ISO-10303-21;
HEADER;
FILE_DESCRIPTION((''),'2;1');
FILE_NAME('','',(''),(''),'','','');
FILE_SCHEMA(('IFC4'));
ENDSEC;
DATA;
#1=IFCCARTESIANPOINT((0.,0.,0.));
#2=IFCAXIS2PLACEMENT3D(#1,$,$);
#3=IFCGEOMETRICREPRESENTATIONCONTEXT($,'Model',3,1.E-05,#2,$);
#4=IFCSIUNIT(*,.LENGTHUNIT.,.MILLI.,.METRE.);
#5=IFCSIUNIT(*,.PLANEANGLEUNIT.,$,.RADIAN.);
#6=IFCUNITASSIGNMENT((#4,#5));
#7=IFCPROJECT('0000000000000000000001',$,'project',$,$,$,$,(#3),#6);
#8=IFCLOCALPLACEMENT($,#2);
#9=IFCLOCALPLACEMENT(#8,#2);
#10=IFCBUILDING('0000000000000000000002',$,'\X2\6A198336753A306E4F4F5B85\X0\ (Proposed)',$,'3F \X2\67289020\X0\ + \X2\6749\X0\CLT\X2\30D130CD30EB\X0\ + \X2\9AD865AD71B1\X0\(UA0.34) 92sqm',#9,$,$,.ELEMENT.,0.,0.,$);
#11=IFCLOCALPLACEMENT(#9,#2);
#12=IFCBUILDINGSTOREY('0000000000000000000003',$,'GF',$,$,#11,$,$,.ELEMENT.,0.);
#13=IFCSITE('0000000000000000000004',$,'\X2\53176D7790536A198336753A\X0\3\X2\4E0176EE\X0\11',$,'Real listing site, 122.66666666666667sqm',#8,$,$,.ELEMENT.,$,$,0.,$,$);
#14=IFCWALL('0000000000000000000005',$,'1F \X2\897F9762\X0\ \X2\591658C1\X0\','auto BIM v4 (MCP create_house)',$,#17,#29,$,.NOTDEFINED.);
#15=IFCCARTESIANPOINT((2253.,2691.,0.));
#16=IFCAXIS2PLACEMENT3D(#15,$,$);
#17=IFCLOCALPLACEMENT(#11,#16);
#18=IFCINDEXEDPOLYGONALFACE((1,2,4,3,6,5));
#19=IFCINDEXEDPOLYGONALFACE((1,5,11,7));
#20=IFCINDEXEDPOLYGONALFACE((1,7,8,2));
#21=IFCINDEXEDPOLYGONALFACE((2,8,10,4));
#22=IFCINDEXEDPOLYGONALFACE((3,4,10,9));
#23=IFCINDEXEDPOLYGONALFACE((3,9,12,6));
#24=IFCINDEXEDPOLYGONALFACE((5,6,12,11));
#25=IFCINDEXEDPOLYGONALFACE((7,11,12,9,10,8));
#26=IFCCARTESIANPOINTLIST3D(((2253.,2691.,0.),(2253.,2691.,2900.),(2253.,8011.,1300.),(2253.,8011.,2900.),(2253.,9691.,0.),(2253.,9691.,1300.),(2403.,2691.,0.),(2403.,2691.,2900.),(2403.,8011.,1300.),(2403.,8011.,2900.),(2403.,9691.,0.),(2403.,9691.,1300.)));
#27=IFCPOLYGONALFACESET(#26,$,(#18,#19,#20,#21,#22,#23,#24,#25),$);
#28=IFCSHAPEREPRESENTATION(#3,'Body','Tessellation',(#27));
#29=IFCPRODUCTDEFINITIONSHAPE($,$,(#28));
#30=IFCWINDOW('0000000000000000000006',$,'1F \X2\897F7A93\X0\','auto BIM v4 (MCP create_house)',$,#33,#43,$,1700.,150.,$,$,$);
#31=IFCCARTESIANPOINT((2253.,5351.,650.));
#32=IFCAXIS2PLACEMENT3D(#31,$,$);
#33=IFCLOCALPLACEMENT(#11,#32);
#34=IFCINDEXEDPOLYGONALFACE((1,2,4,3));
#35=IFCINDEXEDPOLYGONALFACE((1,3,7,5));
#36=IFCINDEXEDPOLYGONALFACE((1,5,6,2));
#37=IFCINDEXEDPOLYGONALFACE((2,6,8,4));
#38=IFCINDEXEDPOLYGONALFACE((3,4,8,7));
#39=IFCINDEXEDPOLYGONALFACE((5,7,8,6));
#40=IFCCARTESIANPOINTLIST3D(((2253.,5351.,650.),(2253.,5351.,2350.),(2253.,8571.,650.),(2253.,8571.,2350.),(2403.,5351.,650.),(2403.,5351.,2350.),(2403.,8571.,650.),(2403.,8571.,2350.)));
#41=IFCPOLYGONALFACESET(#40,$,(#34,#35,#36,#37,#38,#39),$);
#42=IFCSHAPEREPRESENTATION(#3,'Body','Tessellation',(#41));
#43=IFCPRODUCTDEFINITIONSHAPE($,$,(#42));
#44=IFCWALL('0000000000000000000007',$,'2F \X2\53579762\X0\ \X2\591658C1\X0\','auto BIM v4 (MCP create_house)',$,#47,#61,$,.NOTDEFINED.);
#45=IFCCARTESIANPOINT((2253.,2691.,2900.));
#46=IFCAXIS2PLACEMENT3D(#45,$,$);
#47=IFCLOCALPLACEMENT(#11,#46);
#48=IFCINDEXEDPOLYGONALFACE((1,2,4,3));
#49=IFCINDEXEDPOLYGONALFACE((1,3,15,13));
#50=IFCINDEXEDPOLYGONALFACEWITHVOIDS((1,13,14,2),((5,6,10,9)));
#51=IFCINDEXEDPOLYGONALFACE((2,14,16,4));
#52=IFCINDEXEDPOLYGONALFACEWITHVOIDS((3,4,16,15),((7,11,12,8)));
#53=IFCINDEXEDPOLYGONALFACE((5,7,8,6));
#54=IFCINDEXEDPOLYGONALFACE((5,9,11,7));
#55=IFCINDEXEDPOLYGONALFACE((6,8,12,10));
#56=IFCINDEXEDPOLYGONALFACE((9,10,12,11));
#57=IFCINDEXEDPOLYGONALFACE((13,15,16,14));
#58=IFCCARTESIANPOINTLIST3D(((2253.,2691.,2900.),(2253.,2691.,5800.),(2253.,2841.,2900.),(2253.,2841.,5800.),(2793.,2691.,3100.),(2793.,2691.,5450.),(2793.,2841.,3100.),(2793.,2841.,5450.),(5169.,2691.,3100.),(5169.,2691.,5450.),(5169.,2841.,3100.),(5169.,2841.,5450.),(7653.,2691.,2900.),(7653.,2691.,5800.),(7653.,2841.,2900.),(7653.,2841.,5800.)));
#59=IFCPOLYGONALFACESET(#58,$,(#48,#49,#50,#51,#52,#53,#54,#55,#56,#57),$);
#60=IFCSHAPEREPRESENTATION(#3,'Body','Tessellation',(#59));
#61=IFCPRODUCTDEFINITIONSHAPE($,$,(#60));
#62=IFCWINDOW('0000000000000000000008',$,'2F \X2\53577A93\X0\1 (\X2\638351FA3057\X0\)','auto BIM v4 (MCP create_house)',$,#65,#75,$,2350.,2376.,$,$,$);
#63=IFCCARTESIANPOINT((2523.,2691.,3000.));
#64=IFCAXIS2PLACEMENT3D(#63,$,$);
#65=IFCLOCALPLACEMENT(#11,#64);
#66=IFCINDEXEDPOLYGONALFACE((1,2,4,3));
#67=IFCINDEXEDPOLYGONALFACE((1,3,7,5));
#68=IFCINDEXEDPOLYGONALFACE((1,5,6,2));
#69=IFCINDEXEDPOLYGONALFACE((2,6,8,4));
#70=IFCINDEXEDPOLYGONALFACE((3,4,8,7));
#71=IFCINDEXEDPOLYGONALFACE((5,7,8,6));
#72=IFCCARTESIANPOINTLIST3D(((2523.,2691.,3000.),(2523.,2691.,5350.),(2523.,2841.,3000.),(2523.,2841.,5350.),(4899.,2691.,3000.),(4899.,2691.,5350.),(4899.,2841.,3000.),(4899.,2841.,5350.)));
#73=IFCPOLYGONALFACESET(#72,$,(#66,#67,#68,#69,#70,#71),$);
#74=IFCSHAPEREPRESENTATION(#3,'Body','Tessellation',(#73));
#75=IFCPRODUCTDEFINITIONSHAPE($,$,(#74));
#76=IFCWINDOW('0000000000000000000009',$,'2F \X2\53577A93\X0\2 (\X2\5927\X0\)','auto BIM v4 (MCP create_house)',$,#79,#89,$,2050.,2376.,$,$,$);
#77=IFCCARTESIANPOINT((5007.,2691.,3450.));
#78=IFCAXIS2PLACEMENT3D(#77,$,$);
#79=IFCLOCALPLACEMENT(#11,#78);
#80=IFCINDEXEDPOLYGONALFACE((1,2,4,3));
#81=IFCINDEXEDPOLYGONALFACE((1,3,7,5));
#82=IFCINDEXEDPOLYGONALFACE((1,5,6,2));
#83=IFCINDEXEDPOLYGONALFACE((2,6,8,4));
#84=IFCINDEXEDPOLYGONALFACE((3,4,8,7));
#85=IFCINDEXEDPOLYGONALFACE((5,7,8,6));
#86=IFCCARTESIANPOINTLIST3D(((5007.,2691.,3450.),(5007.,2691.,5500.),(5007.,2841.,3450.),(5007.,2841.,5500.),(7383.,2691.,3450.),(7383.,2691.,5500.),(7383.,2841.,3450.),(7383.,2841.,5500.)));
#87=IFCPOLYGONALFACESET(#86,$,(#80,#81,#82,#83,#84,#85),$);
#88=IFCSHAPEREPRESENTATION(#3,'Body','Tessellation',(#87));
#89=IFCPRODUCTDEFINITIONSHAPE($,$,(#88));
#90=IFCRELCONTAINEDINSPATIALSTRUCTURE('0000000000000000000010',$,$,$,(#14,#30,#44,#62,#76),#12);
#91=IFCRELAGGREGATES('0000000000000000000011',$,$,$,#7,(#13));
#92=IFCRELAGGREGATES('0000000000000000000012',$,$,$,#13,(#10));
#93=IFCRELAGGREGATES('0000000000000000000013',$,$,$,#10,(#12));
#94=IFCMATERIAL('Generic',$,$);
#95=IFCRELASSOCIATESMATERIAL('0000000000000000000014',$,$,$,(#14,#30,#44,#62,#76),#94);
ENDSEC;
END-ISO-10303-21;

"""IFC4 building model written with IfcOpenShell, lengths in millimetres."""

from ifc_helpers import new_model, si_unit, frame, frame_2d, origin, place, context, project, spatial, rectangle, extrude, material, element, fill, save


model = new_model("IFC4")

# Units and contexts
model_context = context("Model", 3, precision=1e-05, world=origin())
ifc_project = project(units=[si_unit("LENGTHUNIT", "METRE", prefix="MILLI"), si_unit("PLANEANGLEUNIT", "RADIAN")], contexts=[model_context])

# Site, building, storey
site_placement = place(None, origin())
site = spatial("IfcSite", under=ifc_project, at=site_placement, Name="北海道標茶町3丁目11", ObjectType="Real listing site, 122.66666666666667sqm", CompositionType="ELEMENT", RefElevation=0.0)
building_placement = place(site_placement, origin())
building = spatial("IfcBuilding", under=site, at=building_placement, Name="標茶町の住宅 (Proposed)", ObjectType="3F 木造 + 杉CLTパネル + 高断熱(UA0.34) 92sqm", CompositionType="ELEMENT", ElevationOfRefHeight=0.0, ElevationOfTerrain=0.0)
storey_placement = place(building_placement, origin())
storey = spatial("IfcBuildingStorey", under=building, at=storey_placement, Name="GF", CompositionType="ELEMENT", Elevation=0.0)

# Shared definitions
ifc_material = material(Name="Generic")

# Wall, opening, window
wall_1_placement = place(storey_placement, frame((2253.0, 2691.0, 0.0)))
wall_1 = element("IfcWall", 1, at=wall_1_placement, inside=storey, material=ifc_material, Name="1F 西面 外壁", Description="auto BIM v4 (MCP create_house)", PredefinedType="NOTDEFINED", context=model_context, shape_type="SweptSolid", body=[
    extrude(rectangle(XDim=150.0, YDim=7000.0, at=frame_2d((75.0, 3500.0))), frame((2253.0, 2691.0, 0.0)), (0.0, 0.0, 1.0), 2900.0),
])
opening_1_placement = place(storey_placement, frame((2253.0, 5351.0, 650.0)))
opening_1 = element("IfcOpeningElement", 2, at=opening_1_placement, cuts=wall_1, PredefinedType="NOTDEFINED", context=model_context, shape_type="SweptSolid", body=[
    extrude(rectangle(XDim=150.0, YDim=3220.0, at=frame_2d((75.0, 1610.0))), frame((2253.0, 5351.0, 650.0)), (0.0, 0.0, 1.0), 1700.0),
])
window_1_placement = place(storey_placement, frame((2253.0, 5351.0, 650.0)))
window_1 = element("IfcWindow", 3, at=window_1_placement, inside=storey, material=ifc_material, Name="1F 西窓", Description="auto BIM v4 (MCP create_house)", OverallHeight=1700.0, OverallWidth=150.0, context=model_context, shape_type="SweptSolid", body=[
    extrude(rectangle(XDim=150.0, YDim=3220.0, at=frame_2d((75.0, 1610.0))), frame((2253.0, 5351.0, 650.0)), (0.0, 0.0, 1.0), 1700.0),
])
fill(opening_1, window_1)

# Wall, openings, windows
wall_2_placement = place(storey_placement, frame((2253.0, 2691.0, 2900.0)))
wall_2 = element("IfcWall", 4, at=wall_2_placement, inside=storey, material=ifc_material, Name="2F 南面 外壁", Description="auto BIM v4 (MCP create_house)", PredefinedType="NOTDEFINED", context=model_context, shape_type="SweptSolid", body=[
    extrude(rectangle(XDim=5400.0, YDim=150.0, at=frame_2d((2700.0, 75.0))), frame((2253.0, 2691.0, 2900.0)), (0.0, 0.0, 1.0), 2900.0),
])
opening_2_placement = place(storey_placement, frame((2523.0, 2691.0, 3000.0)))
opening_2 = element("IfcOpeningElement", 5, at=opening_2_placement, cuts=wall_2, PredefinedType="NOTDEFINED", context=model_context, shape_type="SweptSolid", body=[
    extrude(rectangle(XDim=2376.0, YDim=150.0, at=frame_2d((1188.0, 75.0))), frame((2523.0, 2691.0, 3000.0)), (0.0, 0.0, 1.0), 2350.0),
])
opening_3_placement = place(storey_placement, frame((5007.0, 2691.0, 3450.0)))
opening_3 = element("IfcOpeningElement", 6, at=opening_3_placement, cuts=wall_2, PredefinedType="NOTDEFINED", context=model_context, shape_type="SweptSolid", body=[
    extrude(rectangle(XDim=2376.0, YDim=150.0, at=frame_2d((1188.0, 75.0))), frame((5007.0, 2691.0, 3450.0)), (0.0, 0.0, 1.0), 2050.0),
])
window_2_placement = place(storey_placement, frame((2523.0, 2691.0, 3000.0)))
window_2 = element("IfcWindow", 7, at=window_2_placement, inside=storey, material=ifc_material, Name="2F 南窓1 (掃出し)", Description="auto BIM v4 (MCP create_house)", OverallHeight=2350.0, OverallWidth=2376.0, context=model_context, shape_type="SweptSolid", body=[
    extrude(rectangle(XDim=2376.0, YDim=150.0, at=frame_2d((1188.0, 75.0))), frame((2523.0, 2691.0, 3000.0)), (0.0, 0.0, 1.0), 2350.0),
])
fill(opening_2, window_2)
window_3_placement = place(storey_placement, frame((5007.0, 2691.0, 3450.0)))
window_3 = element("IfcWindow", 8, at=window_3_placement, inside=storey, material=ifc_material, Name="2F 南窓2 (大)", Description="auto BIM v4 (MCP create_house)", OverallHeight=2050.0, OverallWidth=2376.0, context=model_context, shape_type="SweptSolid", body=[
    extrude(rectangle(XDim=2376.0, YDim=150.0, at=frame_2d((1188.0, 75.0))), frame((5007.0, 2691.0, 3450.0)), (0.0, 0.0, 1.0), 2050.0),
])
fill(opening_3, window_3)

save(model, "model.ifc")
